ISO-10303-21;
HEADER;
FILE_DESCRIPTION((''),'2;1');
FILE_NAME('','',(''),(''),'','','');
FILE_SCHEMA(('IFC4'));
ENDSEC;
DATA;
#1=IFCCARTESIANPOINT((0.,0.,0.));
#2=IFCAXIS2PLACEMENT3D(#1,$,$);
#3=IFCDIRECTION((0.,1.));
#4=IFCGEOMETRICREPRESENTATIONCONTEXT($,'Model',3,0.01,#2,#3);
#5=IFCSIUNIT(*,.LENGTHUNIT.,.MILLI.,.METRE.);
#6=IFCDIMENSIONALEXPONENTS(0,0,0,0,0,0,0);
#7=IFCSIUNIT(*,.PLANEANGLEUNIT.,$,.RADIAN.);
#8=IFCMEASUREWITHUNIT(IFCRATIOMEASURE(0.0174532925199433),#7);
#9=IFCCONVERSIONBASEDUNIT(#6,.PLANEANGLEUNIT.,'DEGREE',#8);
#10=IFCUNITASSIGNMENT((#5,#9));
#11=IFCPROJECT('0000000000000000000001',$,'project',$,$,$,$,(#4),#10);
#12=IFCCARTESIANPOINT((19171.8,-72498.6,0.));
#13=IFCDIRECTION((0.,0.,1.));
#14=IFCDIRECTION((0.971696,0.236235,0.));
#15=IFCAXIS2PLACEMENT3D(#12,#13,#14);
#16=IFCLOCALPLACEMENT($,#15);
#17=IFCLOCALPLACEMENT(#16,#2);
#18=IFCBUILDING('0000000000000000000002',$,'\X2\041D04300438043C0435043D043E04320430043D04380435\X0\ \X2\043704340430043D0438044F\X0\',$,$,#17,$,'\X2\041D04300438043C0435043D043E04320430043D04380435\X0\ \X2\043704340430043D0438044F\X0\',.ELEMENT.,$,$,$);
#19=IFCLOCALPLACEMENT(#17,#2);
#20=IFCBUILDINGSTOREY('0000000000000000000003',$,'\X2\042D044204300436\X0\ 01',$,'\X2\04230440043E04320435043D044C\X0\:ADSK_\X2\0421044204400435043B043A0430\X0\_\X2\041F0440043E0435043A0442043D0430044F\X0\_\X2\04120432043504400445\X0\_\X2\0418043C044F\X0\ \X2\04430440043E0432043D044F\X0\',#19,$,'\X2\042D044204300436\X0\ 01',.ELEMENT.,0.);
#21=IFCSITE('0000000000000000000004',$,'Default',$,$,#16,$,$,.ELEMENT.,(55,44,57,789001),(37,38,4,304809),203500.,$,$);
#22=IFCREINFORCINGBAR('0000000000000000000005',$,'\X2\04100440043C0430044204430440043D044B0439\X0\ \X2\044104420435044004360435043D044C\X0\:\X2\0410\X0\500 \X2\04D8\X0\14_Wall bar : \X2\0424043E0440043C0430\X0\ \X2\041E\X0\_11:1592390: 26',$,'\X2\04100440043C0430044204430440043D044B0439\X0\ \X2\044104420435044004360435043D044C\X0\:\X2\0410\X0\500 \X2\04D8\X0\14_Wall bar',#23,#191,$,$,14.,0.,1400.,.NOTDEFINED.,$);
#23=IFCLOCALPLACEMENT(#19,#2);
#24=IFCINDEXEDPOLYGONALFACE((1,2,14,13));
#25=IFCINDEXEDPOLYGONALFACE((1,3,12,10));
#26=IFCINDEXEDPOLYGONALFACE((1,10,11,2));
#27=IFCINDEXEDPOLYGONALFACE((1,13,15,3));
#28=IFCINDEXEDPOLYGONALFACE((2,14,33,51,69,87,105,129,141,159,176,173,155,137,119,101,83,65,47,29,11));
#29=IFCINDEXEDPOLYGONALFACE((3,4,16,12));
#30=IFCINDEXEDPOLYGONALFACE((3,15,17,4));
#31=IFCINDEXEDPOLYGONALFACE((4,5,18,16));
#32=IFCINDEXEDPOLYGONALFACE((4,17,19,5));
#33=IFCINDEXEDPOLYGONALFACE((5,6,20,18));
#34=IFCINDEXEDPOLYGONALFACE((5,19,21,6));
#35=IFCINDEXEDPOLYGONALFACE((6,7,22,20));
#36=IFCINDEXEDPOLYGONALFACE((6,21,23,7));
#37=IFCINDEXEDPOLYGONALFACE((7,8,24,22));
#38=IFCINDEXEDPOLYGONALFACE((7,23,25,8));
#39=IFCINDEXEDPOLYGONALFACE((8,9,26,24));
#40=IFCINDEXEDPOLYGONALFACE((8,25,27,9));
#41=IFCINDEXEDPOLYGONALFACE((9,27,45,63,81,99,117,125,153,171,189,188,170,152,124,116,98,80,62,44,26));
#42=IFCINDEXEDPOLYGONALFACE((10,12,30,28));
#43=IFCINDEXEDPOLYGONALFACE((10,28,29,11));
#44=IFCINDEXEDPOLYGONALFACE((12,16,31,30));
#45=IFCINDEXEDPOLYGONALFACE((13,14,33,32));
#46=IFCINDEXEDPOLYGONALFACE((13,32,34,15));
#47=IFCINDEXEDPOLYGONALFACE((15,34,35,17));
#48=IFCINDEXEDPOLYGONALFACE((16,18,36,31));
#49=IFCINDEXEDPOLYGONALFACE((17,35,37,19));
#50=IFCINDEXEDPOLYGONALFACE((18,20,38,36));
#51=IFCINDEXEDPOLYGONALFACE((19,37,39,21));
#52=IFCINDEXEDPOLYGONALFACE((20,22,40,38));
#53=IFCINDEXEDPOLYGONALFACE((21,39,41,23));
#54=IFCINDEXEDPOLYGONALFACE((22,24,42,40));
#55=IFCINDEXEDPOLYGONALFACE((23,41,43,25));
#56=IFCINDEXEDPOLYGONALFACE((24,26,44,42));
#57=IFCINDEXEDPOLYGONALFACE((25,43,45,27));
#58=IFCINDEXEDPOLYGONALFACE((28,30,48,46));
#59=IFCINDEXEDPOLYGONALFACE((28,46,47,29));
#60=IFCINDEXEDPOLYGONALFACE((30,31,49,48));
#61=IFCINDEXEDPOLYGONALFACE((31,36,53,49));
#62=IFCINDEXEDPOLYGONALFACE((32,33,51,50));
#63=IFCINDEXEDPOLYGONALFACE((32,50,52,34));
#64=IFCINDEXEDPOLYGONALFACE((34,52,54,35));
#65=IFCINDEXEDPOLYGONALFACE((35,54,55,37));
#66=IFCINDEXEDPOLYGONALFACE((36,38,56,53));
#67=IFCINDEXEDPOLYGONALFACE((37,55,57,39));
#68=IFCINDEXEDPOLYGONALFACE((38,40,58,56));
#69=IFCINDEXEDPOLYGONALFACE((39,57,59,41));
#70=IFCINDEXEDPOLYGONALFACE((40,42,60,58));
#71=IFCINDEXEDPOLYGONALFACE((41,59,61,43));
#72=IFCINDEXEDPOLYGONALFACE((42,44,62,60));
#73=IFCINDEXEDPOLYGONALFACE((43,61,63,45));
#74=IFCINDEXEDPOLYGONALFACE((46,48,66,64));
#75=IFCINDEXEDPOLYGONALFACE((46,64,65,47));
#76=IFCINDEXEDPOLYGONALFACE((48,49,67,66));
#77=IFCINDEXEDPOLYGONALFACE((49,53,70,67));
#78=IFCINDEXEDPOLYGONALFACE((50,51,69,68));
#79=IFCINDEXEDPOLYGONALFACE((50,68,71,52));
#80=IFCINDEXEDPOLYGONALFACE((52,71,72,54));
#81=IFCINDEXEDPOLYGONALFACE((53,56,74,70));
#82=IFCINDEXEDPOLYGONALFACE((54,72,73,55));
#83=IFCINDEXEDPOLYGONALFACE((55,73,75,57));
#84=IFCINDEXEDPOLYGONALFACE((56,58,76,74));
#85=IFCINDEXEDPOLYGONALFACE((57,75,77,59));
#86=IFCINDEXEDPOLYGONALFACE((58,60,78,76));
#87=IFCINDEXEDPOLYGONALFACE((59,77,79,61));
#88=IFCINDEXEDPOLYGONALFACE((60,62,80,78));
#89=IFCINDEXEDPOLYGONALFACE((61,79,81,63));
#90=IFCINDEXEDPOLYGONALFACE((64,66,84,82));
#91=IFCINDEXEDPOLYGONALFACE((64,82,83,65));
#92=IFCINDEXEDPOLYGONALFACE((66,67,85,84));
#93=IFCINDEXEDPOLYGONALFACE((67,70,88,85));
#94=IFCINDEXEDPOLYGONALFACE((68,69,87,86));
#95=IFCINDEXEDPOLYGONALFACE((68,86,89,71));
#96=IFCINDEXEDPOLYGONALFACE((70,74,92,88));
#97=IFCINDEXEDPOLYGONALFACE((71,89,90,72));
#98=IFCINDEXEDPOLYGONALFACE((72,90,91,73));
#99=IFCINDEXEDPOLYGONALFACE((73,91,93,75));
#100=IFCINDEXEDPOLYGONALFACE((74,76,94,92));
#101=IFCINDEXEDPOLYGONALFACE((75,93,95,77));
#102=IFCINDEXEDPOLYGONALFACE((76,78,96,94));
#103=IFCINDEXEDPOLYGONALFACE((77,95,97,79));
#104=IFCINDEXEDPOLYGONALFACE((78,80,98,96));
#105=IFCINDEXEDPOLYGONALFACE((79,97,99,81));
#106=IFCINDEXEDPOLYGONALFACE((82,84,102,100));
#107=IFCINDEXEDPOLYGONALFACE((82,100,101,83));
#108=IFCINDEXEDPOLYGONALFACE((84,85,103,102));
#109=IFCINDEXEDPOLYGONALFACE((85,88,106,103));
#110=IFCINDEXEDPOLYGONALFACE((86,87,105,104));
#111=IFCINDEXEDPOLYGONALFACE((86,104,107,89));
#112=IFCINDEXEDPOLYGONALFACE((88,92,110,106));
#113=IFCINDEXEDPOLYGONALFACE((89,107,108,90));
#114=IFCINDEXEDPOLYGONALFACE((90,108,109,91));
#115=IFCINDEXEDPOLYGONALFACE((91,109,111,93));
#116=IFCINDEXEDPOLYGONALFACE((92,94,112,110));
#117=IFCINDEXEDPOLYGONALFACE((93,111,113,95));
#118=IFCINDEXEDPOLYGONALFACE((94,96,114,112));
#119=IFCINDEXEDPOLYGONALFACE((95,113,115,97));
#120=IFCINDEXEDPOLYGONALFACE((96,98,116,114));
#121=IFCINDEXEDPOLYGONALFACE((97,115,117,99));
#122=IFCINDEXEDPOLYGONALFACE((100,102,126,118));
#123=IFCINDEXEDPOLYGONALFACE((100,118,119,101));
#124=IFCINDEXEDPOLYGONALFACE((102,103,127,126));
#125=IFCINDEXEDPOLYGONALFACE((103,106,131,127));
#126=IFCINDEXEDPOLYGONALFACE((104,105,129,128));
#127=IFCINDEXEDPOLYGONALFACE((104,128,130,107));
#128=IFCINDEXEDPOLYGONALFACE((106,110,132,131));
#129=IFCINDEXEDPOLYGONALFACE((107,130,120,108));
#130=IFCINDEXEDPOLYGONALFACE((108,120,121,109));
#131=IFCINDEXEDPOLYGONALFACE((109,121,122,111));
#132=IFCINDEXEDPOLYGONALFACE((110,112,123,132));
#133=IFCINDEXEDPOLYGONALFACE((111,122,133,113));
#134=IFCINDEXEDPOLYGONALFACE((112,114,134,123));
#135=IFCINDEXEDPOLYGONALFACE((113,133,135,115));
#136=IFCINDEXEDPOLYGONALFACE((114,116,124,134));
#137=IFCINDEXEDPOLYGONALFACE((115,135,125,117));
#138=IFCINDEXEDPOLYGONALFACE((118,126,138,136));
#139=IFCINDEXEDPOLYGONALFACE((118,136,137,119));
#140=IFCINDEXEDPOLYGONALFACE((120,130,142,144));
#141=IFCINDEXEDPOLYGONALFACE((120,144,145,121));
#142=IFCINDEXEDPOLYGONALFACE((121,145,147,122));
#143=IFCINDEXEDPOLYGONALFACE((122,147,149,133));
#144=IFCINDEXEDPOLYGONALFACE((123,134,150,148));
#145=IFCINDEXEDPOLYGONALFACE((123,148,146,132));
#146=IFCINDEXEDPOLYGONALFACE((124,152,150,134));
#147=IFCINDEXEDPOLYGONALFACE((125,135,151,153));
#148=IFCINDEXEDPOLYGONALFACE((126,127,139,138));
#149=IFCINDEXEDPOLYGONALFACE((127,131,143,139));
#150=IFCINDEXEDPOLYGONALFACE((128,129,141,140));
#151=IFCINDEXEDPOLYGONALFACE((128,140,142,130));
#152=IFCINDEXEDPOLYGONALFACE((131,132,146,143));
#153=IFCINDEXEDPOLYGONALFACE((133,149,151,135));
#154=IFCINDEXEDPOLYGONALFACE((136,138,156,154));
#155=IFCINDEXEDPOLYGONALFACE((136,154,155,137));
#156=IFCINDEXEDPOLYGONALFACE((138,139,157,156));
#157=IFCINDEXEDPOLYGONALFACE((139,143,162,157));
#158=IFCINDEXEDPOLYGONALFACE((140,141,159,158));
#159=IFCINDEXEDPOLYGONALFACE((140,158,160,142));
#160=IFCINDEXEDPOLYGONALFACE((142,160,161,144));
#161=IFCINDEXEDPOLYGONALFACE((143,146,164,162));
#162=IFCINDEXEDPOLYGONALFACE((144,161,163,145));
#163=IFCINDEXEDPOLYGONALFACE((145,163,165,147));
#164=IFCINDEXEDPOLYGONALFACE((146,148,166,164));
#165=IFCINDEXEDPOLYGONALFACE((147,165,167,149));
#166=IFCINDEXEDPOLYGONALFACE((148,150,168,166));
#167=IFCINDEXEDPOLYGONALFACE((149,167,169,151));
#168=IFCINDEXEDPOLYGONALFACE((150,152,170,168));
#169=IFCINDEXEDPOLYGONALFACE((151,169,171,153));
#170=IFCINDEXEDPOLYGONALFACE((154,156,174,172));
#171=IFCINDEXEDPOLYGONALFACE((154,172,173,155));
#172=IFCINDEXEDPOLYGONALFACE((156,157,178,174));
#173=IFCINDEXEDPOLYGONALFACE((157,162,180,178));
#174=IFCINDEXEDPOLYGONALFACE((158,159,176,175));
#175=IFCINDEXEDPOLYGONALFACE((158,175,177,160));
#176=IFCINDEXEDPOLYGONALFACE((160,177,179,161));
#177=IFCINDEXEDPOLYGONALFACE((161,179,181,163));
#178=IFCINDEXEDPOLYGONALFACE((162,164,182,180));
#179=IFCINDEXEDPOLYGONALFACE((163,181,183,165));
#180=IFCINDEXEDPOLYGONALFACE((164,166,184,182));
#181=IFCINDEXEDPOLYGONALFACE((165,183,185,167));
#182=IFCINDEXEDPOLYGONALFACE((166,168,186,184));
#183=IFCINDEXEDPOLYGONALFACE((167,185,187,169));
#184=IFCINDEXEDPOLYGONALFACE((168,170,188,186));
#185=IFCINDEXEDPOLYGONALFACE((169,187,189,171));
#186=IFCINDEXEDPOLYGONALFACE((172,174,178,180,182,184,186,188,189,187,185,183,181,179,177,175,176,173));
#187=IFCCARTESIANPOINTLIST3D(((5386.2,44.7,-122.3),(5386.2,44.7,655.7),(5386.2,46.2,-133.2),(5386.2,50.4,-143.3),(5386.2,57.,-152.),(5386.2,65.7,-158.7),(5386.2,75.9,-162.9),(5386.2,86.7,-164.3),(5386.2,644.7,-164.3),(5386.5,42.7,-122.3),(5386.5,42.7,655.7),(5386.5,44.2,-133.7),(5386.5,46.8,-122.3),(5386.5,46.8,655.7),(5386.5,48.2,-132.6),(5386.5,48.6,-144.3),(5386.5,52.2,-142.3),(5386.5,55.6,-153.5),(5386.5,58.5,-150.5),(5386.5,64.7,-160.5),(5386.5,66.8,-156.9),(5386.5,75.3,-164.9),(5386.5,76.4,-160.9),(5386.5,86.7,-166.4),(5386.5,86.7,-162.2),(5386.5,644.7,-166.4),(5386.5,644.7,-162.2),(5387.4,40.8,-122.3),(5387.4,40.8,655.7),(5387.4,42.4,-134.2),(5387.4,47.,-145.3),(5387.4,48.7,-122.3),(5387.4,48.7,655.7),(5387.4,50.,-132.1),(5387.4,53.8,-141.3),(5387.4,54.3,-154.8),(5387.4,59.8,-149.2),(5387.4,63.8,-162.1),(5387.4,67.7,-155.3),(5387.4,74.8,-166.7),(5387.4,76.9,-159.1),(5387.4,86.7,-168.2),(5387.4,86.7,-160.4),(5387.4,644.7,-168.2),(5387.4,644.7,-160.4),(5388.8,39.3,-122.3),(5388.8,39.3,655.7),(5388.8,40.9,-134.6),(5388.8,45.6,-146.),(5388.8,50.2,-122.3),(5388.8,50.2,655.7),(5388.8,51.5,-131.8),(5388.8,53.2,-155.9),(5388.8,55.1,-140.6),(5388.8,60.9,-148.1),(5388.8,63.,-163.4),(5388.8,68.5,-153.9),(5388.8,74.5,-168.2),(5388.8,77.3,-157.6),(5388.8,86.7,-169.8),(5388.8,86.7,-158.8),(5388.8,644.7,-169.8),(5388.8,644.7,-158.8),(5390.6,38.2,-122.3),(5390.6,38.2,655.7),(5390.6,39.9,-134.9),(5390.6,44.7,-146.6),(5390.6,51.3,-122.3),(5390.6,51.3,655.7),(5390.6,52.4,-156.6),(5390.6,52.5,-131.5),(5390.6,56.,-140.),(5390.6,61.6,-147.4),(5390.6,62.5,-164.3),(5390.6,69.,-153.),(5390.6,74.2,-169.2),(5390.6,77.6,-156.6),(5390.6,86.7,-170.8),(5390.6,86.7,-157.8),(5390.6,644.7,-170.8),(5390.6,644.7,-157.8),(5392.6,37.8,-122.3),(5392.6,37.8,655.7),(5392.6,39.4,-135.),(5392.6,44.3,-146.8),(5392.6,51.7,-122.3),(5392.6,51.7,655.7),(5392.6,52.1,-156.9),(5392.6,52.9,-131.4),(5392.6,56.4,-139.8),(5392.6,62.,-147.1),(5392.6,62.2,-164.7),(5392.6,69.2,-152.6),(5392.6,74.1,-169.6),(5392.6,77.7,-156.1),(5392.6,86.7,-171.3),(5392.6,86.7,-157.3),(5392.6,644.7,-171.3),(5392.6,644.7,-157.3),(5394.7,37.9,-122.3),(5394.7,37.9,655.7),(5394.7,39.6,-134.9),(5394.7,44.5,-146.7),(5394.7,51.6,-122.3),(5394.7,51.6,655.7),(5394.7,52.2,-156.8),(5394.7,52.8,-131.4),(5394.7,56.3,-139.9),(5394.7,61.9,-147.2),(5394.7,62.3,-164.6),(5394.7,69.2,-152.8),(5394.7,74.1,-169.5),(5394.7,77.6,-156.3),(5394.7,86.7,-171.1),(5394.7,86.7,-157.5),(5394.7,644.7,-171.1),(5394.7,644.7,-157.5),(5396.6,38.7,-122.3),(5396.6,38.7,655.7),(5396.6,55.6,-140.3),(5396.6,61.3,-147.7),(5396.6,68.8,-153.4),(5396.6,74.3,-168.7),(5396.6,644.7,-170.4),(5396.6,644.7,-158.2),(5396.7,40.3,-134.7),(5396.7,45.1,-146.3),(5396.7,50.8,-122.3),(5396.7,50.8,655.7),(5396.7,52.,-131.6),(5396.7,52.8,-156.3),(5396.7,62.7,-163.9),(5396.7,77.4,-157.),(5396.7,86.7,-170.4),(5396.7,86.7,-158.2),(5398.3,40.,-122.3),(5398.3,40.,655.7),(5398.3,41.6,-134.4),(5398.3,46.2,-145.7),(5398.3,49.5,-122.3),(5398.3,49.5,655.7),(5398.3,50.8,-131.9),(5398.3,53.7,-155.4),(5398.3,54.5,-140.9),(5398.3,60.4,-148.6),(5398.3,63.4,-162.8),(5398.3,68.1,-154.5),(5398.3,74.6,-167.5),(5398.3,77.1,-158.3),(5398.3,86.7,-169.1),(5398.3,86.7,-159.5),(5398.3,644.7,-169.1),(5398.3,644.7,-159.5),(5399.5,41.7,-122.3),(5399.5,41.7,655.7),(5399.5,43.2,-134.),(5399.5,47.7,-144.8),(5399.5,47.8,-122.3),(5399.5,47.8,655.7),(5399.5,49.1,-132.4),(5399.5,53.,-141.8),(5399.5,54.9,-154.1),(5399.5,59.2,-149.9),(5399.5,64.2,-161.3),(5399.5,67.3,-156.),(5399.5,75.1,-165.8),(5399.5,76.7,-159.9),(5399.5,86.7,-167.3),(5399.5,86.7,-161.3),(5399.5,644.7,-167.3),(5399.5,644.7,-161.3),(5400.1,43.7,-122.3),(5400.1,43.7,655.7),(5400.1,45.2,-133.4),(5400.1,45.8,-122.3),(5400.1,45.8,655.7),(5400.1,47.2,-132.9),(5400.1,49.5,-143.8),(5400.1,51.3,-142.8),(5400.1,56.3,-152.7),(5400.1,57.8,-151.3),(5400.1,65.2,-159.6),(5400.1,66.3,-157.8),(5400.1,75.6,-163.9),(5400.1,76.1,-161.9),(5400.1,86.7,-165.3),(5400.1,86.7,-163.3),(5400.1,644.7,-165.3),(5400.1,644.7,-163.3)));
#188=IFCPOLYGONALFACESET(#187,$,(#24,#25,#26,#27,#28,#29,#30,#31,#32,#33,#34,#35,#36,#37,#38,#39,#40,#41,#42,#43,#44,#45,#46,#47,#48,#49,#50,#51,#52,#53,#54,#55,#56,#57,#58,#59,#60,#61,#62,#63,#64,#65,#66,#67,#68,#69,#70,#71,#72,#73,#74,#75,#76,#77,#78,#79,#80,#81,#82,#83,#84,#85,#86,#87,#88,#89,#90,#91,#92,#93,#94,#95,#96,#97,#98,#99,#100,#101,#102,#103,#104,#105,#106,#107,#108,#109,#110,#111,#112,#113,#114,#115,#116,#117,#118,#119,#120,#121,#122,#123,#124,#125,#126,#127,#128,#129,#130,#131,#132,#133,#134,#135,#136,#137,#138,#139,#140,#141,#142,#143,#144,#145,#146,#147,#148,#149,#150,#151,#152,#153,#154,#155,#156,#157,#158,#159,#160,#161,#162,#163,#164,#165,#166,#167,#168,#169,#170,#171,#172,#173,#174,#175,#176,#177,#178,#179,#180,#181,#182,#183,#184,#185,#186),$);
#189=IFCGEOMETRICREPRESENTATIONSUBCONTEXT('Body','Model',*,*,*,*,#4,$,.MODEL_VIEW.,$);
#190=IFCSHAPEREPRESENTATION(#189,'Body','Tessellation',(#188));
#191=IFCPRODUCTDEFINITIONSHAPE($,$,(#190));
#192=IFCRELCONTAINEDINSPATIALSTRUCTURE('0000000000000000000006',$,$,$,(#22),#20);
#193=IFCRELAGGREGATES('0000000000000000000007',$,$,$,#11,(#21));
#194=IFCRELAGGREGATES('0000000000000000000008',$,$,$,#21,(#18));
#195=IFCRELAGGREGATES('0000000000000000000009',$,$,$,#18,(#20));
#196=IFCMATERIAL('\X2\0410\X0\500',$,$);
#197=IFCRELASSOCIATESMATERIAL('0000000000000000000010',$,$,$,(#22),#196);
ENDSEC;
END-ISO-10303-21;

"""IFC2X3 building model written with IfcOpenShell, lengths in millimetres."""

from ifc_helpers import new_model, entity, si_unit, converted_unit, direction, frame, origin, place, context, subcontext, project, spatial, material, element, save


model = new_model("IFC2X3")

# Units and contexts
model_context = context("Model", 3, precision=0.01, world=origin(), true_north=direction((0.0, 1.0)))
body_context = subcontext(model_context, "Body", "Model", "MODEL_VIEW")
ifc_project = project(units=[si_unit("LENGTHUNIT", "METRE", prefix="MILLI"), converted_unit("PLANEANGLEUNIT", "DEGREE", entity("IfcRatioMeasure", 0.0174532925199433), si_unit("PLANEANGLEUNIT", "RADIAN"), dimensions=[0, 0, 0, 0, 0, 0, 0])], contexts=[model_context])

# Site, building, storey
site_placement = place(None, frame((19171.8, -72498.6, 0.0), z_axis=(0.0, 0.0, 1.0), x_axis=(0.971696, 0.236235, 0.0)))
site = spatial("IfcSite", under=ifc_project, at=site_placement, Name="Default", CompositionType="ELEMENT", RefLatitude=(55, 44, 57, 789001), RefLongitude=(37, 38, 4, 304809), RefElevation=203500.0)
building_placement = place(site_placement, origin())
building = spatial("IfcBuilding", under=site, at=building_placement, Name="Наименование здания", LongName="Наименование здания", CompositionType="ELEMENT")
storey_placement = place(building_placement, origin())
storey = spatial("IfcBuildingStorey", under=building, at=storey_placement, Name="Этаж 01", ObjectType="Уровень:ADSK_Стрелка_Проектная_Вверх_Имя уровня", LongName="Этаж 01", CompositionType="ELEMENT", Elevation=0.0)

# Reinforcing bar
ifc_material = material(Name="А500")
placement = place(storey_placement, origin())
element("IfcReinforcingBar", 1, at=placement, inside=storey, material=ifc_material, Name="Арматурный стержень:А500 Ә14_Wall bar : Форма О_11:1592390: 26", ObjectType="Арматурный стержень:А500 Ә14_Wall bar", BarLength=1400.0, BarRole="NOTDEFINED", CrossSectionArea=0.0, NominalDiameter=14.0, context=body_context, shape_type="AdvancedSweptSolid", body=[
    entity("IfcSweptDiskSolid", entity("IfcCompositeCurve", [entity("IfcCompositeCurveSegment", "CONTINUOUS", True, entity("IfcPolyline", [entity("IfcCartesianPoint", [5393.1, 44.7, 655.7]), entity("IfcCartesianPoint", [5393.1, 44.7, -122.3])])), entity("IfcCompositeCurveSegment", "CONTINUOUS", True, entity("IfcTrimmedCurve", entity("IfcCircle", entity("IfcAxis2Placement3D", entity("IfcCartesianPoint", [5393.1, 86.7, -122.3]), entity("IfcDirection", [1.0, 0.0, 0.0]), entity("IfcDirection", [0.0, 0.0, -1.0])), 42.0), [entity("IfcParameterValue", 270.0)], [entity("IfcParameterValue", 360.0)], True, "PARAMETER")), entity("IfcCompositeCurveSegment", "CONTINUOUS", True, entity("IfcPolyline", [entity("IfcCartesianPoint", [5393.1, 86.7, -164.3]), entity("IfcCartesianPoint", [5393.1, 644.7, -164.3])]))], False), 7.0, None, 0.0, 92.0),
])

save(model, "model.ifc")
